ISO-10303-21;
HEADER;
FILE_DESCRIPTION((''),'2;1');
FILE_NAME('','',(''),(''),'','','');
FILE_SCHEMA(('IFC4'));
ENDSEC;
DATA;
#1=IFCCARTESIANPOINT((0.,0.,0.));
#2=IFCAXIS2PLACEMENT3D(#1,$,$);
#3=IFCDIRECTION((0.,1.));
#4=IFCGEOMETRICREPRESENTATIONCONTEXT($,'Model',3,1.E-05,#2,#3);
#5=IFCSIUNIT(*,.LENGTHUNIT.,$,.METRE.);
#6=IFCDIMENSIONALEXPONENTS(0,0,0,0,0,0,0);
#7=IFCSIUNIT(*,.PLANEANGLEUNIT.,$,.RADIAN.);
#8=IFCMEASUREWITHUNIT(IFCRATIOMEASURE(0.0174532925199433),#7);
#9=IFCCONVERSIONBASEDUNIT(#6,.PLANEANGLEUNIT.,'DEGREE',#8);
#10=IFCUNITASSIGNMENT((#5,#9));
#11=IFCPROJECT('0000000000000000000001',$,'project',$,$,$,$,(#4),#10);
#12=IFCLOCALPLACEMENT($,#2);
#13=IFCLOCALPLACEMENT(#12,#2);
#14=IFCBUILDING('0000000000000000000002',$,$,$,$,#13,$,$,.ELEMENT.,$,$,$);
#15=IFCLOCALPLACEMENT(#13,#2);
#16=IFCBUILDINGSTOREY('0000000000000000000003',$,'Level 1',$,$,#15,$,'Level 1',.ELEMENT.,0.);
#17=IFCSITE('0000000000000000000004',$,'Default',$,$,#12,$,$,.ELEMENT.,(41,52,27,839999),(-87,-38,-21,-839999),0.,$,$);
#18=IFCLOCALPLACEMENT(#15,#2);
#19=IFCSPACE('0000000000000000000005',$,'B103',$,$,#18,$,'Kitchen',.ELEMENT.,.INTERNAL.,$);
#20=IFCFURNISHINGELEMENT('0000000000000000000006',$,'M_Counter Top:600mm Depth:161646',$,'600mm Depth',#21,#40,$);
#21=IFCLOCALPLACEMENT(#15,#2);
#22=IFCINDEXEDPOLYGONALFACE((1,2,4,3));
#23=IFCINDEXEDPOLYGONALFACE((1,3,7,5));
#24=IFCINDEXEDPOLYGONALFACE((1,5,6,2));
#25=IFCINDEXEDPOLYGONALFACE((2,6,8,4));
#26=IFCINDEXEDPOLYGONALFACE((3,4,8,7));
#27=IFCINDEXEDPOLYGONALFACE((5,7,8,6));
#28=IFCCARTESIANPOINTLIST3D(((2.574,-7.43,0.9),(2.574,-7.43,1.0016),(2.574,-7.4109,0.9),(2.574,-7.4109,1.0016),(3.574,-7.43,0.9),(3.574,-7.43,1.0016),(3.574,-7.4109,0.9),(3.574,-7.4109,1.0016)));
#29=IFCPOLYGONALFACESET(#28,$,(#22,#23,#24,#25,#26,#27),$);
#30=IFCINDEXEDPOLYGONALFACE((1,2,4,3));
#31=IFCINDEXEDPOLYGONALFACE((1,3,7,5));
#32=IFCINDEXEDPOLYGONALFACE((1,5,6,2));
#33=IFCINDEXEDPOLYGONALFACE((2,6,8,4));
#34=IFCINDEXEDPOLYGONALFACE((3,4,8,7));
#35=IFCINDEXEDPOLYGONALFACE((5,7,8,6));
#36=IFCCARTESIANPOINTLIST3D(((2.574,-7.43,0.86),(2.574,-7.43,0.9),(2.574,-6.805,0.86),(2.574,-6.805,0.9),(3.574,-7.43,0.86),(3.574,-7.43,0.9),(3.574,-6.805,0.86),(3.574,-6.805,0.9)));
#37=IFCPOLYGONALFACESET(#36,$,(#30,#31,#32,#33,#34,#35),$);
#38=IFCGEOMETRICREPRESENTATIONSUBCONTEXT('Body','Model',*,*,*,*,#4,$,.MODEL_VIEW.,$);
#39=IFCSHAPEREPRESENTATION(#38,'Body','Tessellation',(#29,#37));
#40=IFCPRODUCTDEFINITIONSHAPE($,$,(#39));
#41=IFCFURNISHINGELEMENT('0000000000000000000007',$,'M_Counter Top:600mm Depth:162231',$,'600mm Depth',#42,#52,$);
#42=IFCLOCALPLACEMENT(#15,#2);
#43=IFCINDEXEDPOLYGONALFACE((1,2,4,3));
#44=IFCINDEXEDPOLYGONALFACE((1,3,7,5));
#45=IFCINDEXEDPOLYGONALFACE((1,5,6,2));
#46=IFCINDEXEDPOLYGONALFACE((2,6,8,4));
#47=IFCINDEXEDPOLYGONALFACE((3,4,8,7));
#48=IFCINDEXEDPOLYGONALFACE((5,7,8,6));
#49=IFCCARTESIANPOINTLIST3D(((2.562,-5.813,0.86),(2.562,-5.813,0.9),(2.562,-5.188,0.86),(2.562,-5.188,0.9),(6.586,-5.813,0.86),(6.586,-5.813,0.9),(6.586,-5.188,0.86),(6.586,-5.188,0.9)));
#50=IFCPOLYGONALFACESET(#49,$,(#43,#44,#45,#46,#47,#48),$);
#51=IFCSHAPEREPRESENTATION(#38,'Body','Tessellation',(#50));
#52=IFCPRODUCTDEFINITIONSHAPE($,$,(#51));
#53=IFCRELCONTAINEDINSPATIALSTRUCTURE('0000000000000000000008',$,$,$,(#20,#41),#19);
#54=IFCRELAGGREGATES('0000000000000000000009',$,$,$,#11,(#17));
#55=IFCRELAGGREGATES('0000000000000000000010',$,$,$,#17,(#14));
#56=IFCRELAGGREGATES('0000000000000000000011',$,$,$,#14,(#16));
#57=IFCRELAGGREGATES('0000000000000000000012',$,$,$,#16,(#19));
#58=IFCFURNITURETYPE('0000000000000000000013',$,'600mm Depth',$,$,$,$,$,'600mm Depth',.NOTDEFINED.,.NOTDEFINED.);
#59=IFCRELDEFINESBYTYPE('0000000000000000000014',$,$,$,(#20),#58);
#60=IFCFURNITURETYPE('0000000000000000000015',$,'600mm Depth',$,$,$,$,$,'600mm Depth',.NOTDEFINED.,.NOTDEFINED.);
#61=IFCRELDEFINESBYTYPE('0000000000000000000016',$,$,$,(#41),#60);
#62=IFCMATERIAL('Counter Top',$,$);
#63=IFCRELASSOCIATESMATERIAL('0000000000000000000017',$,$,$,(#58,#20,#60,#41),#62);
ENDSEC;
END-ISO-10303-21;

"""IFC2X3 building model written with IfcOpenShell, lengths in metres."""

from ifc_helpers import new_model, entity, si_unit, converted_unit, direction, frame, frame_2d, origin, place, context, subcontext, project, spatial, rectangle, extrude, source, transform, mapped, material, type_object, type_shapes, element, save


model = new_model("IFC2X3")

# Units and contexts
model_context = context("Model", 3, precision=1e-05, world=origin(), true_north=direction((0.0, 1.0)))
body_context = subcontext(model_context, "Body", "Model", "MODEL_VIEW")
ifc_project = project(units=[si_unit("LENGTHUNIT", "METRE"), converted_unit("PLANEANGLEUNIT", "DEGREE", entity("IfcRatioMeasure", 0.0174532925199433), si_unit("PLANEANGLEUNIT", "RADIAN"), dimensions=[0, 0, 0, 0, 0, 0, 0])], contexts=[model_context])

# Site, building, storey
site_placement = place(None, origin())
site = spatial("IfcSite", under=ifc_project, at=site_placement, Name="Default", CompositionType="ELEMENT", RefLatitude=(41, 52, 27, 839999), RefLongitude=(-87, -38, -21, -839999), RefElevation=0.0)
building_placement = place(site_placement, origin())
building = spatial("IfcBuilding", under=site, at=building_placement, CompositionType="ELEMENT")
storey_placement = place(building_placement, origin())
storey = spatial("IfcBuildingStorey", under=building, at=storey_placement, Name="Level 1", LongName="Level 1", CompositionType="ELEMENT", Elevation=0.0)

# Shared definitions
space_1_placement = place(storey_placement, origin())
space_1 = spatial("IfcSpace", under=storey, at=space_1_placement, Name="B103", LongName="Kitchen", CompositionType="ELEMENT", InteriorOrExteriorSpace="INTERNAL")

# Shared definitions
ifc_material_1 = material(Name="Counter Top")

# Furnishing elements
furniture_type_1 = type_object("IfcFurnitureType", Name="600mm Depth", ElementType="600mm Depth", AssemblyPlace="NOTDEFINED", material=ifc_material_1)
shared_shape_1 = source(origin(), body_context, "Body", "SweptSolid", [
    extrude(rectangle(XDim=0.0191, YDim=1.0, at=frame_2d((0.0, 0.0), x_axis=(1.0, 0.0))), frame((-0.7005, -0.0095, 0.9), z_axis=(0.0, 0.0, 1.0), x_axis=(0.0, -1.0, 0.0)), (0.0, 0.0, 1.0), 0.1016),
    extrude(rectangle(XDim=1.0, YDim=0.625, at=frame_2d((0.0, 0.0), x_axis=(1.0, 0.0))), frame((-0.7005, -0.3125, 0.86), z_axis=(0.0, 0.0, 1.0), x_axis=(-1.0, 0.0, 0.0)), (0.0, 0.0, 1.0), 0.04),
])
type_shapes(furniture_type_1, [shared_shape_1])
furnishing_1_placement = place(space_1_placement, frame((2.3735, -7.43, 0.0), z_axis=(0.0, 0.0, 1.0), x_axis=(-1.0, 0.0, 0.0)))
element("IfcFurnishingElement", 1, at=furnishing_1_placement, inside=space_1, type_object=furniture_type_1, material=ifc_material_1, Name="M_Counter Top:600mm Depth:161646", ObjectType="600mm Depth", context=body_context, shape_type="MappedRepresentation", body=[
    mapped(shared_shape_1, transform((0.0, 0.0, 0.0), scale=1.0)),
])
furniture_type_2 = type_object("IfcFurnitureType", Name="600mm Depth", ElementType="600mm Depth", AssemblyPlace="NOTDEFINED", material=ifc_material_1)
shared_shape_2 = source(origin(), body_context, "Body", "SweptSolid", [
    extrude(rectangle(XDim=4.024, YDim=0.625, at=frame_2d((0.0, 0.0), x_axis=(1.0, 0.0))), frame((0.8115, -0.3125, 0.86), z_axis=(0.0, 0.0, 1.0), x_axis=(-1.0, 0.0, 0.0)), (0.0, 0.0, 1.0), 0.04),
])
type_shapes(furniture_type_2, [shared_shape_2])
furnishing_2_placement = place(space_1_placement, frame((3.7625, -5.188, 0.0)))
element("IfcFurnishingElement", 2, at=furnishing_2_placement, inside=space_1, type_object=furniture_type_2, material=ifc_material_1, Name="M_Counter Top:600mm Depth:162231", ObjectType="600mm Depth", context=body_context, shape_type="MappedRepresentation", body=[
    mapped(shared_shape_2, transform((0.0, 0.0, 0.0), scale=1.0)),
])

save(model, "model.ifc")
